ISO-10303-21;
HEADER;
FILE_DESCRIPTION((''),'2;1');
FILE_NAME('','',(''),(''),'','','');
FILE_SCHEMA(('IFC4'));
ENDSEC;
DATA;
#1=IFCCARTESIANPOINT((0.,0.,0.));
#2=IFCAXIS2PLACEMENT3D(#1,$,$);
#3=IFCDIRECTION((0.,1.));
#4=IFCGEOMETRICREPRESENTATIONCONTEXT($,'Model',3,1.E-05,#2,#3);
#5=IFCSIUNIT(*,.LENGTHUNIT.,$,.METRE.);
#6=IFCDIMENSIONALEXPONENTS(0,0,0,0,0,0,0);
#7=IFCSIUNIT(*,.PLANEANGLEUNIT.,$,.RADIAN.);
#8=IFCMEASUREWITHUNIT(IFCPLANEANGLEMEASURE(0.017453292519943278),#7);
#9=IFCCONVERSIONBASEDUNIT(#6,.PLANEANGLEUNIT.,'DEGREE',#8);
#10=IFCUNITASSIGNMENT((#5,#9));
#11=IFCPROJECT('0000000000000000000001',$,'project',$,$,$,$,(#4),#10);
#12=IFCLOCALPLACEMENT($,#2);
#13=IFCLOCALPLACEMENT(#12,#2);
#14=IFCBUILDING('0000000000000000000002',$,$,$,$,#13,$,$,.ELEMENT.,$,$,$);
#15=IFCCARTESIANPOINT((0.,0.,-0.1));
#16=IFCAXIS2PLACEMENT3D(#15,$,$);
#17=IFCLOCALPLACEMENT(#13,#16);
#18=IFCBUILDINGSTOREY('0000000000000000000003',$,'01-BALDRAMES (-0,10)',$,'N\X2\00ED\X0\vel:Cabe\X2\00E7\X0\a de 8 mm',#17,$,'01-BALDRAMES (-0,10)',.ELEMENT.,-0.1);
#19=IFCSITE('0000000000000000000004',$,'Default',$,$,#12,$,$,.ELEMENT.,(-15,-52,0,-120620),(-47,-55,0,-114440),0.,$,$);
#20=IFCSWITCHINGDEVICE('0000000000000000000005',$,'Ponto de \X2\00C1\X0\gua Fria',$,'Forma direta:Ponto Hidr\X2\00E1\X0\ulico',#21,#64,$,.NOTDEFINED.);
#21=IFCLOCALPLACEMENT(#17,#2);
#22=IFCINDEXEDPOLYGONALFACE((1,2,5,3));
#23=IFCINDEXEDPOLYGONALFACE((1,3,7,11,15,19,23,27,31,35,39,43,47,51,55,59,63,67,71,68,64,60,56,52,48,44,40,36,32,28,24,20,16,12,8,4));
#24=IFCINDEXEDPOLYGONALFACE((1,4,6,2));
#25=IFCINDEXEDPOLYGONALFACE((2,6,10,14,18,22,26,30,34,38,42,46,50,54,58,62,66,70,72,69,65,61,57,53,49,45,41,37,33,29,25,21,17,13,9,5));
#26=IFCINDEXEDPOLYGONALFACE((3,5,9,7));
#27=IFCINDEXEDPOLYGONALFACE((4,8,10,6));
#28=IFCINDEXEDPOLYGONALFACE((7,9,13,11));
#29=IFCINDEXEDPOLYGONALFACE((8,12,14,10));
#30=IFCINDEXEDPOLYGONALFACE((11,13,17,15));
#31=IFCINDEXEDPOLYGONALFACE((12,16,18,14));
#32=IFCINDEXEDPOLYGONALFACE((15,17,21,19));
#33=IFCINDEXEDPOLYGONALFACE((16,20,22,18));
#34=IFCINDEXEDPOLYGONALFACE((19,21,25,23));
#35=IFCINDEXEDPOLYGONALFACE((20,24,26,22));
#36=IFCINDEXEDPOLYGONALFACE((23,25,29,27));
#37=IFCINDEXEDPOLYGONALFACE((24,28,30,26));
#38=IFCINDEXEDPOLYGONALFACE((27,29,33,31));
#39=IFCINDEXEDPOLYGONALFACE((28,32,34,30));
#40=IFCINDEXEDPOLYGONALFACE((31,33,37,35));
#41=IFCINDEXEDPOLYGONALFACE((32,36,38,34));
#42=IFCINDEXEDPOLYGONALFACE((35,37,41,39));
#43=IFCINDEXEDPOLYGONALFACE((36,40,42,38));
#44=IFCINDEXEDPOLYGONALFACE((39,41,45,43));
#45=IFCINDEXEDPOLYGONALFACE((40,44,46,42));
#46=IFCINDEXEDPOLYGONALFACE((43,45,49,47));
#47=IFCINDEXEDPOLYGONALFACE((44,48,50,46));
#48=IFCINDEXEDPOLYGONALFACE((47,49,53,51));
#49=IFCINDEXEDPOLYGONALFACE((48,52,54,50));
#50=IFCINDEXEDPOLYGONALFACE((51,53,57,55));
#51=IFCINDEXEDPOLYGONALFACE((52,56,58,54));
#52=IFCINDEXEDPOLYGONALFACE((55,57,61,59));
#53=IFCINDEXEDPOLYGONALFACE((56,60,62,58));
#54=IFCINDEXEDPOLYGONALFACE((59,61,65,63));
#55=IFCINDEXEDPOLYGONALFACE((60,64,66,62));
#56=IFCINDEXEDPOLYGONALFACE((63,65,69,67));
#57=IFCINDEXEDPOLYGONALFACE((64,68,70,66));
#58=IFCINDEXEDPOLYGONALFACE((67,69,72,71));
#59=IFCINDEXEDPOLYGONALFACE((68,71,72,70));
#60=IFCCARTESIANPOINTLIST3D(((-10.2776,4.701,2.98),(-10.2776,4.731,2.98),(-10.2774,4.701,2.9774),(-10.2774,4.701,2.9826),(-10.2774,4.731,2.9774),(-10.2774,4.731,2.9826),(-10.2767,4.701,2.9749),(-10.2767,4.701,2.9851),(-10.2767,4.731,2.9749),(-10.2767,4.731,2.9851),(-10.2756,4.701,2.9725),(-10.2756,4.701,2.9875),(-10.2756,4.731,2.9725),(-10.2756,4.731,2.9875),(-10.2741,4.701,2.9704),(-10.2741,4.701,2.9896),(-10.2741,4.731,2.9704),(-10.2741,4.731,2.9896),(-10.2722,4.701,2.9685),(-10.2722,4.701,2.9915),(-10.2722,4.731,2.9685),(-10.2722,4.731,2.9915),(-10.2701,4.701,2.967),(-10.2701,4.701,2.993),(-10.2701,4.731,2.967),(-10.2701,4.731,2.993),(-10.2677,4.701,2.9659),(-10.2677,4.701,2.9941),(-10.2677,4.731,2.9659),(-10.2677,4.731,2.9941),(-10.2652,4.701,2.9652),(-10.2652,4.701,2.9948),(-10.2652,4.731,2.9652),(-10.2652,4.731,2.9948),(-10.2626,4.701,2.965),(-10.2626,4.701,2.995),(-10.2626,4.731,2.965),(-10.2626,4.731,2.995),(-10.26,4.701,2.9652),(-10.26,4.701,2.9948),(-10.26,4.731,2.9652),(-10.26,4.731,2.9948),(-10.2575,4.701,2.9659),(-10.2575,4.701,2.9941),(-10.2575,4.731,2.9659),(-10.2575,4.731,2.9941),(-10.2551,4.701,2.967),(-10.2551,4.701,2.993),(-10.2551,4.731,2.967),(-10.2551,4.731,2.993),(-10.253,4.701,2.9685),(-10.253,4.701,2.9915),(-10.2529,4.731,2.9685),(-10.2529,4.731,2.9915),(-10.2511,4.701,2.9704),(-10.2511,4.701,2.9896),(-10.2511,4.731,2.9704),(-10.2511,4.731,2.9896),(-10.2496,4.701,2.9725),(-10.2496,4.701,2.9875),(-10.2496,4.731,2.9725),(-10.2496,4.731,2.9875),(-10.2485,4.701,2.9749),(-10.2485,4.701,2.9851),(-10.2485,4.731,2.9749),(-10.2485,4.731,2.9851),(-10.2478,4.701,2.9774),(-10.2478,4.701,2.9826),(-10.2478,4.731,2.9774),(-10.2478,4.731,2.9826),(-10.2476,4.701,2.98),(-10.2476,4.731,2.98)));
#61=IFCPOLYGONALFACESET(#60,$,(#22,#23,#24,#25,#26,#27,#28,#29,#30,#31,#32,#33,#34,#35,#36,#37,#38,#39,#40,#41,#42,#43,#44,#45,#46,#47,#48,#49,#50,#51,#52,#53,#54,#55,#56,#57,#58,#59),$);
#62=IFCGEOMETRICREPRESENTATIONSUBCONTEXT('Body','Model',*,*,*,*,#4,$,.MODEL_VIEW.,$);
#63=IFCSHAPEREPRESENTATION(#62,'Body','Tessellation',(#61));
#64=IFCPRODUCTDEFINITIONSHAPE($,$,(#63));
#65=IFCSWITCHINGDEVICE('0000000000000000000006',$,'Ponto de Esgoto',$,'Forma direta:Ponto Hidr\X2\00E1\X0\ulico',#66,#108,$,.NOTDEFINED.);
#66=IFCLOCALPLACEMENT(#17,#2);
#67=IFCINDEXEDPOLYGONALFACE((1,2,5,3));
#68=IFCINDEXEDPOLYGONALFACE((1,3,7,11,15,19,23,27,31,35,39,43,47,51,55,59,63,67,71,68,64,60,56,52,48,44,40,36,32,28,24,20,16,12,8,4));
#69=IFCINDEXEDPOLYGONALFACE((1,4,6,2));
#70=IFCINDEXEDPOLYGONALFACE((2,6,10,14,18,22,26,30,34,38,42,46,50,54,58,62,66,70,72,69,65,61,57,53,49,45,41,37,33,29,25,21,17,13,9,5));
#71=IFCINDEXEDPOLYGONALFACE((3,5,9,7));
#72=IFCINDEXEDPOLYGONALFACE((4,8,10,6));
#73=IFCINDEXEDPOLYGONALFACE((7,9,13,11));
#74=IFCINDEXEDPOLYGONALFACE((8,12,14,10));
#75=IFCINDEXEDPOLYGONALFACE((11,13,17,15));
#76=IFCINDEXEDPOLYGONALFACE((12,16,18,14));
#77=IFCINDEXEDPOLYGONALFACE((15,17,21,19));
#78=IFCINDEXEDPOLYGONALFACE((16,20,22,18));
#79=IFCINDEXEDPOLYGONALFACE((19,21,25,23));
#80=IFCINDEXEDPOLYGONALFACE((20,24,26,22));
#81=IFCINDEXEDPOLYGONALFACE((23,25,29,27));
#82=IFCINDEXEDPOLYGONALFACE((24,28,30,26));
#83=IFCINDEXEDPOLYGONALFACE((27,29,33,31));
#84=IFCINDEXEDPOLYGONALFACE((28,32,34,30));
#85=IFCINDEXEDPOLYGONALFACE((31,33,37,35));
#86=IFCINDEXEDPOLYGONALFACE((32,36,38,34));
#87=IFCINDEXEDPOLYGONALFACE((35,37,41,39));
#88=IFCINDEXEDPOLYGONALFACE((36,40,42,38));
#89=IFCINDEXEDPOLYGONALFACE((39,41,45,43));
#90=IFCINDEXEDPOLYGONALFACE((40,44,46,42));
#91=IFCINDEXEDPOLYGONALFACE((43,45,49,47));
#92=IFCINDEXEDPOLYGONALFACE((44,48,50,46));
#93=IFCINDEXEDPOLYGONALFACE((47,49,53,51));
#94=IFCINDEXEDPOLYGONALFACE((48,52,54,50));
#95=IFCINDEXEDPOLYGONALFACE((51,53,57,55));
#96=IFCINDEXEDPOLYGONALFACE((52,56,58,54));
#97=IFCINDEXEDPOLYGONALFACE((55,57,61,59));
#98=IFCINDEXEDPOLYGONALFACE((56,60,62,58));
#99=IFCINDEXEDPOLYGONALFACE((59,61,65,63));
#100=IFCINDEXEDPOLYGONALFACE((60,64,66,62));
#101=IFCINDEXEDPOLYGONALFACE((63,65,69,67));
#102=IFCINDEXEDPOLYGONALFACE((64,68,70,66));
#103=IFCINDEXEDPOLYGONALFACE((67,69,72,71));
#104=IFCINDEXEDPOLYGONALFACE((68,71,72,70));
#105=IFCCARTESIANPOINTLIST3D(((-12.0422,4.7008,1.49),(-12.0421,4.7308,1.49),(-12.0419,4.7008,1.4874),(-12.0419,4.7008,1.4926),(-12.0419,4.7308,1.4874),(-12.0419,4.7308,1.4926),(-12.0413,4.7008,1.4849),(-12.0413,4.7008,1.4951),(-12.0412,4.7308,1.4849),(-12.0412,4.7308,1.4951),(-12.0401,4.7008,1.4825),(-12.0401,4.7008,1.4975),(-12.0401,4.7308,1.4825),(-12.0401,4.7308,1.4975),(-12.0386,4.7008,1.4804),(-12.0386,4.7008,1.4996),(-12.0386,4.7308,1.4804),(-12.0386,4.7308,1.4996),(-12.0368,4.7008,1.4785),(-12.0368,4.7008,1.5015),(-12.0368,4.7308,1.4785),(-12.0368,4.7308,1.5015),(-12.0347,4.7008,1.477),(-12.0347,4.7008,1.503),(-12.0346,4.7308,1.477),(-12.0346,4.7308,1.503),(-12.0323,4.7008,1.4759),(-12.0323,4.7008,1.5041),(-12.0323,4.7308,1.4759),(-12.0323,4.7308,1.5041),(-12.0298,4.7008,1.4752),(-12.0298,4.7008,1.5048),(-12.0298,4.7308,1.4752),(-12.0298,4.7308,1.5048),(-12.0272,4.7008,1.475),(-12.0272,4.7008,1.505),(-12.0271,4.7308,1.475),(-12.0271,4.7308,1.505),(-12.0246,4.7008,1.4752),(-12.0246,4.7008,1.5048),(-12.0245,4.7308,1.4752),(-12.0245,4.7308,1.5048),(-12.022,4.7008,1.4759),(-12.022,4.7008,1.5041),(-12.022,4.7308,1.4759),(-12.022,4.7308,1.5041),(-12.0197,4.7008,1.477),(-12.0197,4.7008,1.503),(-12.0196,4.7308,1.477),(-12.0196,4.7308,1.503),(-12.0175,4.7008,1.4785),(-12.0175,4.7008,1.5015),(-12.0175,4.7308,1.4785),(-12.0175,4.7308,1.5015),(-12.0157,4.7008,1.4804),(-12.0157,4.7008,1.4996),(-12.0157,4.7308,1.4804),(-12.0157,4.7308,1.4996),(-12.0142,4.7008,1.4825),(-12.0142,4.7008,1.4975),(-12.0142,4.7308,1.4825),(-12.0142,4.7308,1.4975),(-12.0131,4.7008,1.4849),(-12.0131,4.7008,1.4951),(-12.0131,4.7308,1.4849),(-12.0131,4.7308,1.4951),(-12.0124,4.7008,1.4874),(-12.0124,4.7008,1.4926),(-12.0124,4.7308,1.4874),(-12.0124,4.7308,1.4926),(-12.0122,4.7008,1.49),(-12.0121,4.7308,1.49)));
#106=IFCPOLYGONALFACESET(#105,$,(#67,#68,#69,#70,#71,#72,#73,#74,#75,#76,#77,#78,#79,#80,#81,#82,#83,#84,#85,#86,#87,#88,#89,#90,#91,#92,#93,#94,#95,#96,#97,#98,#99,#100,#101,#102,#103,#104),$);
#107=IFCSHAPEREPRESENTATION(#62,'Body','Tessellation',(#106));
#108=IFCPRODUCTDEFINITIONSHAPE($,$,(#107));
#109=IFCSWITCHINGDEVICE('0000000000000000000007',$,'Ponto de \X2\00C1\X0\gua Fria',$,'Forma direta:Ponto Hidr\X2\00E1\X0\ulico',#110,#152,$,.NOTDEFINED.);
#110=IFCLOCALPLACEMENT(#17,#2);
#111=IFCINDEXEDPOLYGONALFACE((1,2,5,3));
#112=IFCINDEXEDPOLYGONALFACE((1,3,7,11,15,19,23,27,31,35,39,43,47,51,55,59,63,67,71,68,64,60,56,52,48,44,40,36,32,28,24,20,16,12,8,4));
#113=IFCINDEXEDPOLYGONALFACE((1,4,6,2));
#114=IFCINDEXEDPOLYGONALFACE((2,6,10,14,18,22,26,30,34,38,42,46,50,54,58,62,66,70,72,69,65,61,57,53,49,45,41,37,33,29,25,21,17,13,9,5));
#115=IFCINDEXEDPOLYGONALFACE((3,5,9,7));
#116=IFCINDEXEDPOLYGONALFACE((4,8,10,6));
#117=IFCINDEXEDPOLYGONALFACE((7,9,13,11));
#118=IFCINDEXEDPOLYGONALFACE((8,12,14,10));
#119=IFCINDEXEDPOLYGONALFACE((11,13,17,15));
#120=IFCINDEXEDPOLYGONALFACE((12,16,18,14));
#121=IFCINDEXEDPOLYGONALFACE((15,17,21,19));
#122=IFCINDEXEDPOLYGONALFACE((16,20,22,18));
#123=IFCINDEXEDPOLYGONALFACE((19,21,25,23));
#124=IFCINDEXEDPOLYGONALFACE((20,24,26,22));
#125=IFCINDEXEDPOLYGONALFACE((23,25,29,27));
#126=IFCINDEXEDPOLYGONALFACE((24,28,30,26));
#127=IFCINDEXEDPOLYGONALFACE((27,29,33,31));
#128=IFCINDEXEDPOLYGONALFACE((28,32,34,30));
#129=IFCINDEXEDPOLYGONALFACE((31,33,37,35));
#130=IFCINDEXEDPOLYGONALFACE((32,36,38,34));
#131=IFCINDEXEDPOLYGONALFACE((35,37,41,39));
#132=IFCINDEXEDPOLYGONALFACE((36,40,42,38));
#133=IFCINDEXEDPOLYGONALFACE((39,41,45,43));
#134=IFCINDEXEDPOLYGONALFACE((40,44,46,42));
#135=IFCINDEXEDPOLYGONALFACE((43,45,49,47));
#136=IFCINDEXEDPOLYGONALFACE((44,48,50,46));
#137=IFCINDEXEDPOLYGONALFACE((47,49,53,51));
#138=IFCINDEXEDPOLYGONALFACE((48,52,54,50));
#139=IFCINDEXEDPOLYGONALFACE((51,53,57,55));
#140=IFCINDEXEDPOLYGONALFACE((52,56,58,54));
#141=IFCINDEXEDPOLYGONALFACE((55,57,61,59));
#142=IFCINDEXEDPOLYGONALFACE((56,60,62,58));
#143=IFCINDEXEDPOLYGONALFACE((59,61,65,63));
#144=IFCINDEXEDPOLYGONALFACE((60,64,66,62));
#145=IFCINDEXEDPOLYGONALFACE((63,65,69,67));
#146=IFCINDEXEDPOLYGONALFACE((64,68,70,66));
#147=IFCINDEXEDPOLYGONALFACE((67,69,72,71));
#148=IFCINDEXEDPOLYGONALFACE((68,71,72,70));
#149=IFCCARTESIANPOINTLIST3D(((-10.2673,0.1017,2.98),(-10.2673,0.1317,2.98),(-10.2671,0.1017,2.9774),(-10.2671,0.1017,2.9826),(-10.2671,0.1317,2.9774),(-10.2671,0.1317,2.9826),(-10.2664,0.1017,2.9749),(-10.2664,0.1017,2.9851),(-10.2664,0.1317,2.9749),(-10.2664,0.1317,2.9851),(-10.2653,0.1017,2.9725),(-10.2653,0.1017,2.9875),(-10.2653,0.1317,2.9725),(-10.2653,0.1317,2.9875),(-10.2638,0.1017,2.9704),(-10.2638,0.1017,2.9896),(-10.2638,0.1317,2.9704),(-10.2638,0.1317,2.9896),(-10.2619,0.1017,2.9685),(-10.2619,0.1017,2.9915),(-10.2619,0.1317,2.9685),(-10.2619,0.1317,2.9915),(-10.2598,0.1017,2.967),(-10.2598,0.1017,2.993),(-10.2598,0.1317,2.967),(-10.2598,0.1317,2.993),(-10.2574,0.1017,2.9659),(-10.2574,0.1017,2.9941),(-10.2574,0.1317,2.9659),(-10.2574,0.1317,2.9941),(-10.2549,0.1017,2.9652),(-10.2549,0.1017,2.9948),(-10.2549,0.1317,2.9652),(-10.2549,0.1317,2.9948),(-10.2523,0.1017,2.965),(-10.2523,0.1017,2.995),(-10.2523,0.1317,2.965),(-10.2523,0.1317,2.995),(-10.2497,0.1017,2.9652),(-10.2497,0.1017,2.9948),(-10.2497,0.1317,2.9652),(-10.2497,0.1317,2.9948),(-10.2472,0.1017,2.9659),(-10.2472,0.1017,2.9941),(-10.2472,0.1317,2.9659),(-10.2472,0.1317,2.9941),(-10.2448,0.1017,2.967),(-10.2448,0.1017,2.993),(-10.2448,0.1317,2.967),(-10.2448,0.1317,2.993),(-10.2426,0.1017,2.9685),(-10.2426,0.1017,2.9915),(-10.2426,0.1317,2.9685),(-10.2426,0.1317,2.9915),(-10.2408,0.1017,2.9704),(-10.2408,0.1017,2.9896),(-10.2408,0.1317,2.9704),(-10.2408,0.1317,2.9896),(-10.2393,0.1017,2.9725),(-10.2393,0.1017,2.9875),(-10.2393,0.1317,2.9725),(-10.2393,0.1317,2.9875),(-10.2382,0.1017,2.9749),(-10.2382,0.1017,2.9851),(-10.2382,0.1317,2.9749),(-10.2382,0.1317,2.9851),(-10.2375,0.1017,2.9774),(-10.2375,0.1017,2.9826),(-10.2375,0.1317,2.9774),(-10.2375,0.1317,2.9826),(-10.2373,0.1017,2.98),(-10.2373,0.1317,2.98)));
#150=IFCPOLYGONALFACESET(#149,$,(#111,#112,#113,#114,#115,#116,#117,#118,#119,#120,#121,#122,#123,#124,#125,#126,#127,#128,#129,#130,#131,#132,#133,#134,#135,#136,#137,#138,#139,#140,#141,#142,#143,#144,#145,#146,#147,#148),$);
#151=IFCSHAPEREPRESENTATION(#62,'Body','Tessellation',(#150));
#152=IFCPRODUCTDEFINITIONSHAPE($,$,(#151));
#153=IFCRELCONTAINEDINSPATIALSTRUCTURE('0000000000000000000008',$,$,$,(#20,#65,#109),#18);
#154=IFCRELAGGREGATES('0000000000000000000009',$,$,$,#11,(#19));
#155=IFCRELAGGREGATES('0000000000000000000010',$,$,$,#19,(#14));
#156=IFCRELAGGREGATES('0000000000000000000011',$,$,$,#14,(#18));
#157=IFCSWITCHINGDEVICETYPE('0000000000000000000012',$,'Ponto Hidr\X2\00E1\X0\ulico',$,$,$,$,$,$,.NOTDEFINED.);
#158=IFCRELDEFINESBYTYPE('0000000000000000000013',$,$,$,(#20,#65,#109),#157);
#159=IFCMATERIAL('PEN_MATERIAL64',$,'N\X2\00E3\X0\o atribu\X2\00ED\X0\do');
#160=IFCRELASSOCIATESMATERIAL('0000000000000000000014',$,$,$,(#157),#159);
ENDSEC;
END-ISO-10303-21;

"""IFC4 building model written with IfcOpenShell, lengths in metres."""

from ifc_helpers import new_model, entity, si_unit, converted_unit, direction, frame, origin, place, context, subcontext, project, spatial, indexed_curve, outline, extrude, material, type_object, element, save


model = new_model("IFC4")

# Units and contexts
model_context = context("Model", 3, precision=1e-05, world=origin(), true_north=direction((0.0, 1.0)))
body_context = subcontext(model_context, "Body", "Model", "MODEL_VIEW")
ifc_project = project(units=[si_unit("LENGTHUNIT", "METRE"), converted_unit("PLANEANGLEUNIT", "DEGREE", entity("IfcPlaneAngleMeasure", 0.017453292519943278), si_unit("PLANEANGLEUNIT", "RADIAN"), dimensions=[0, 0, 0, 0, 0, 0, 0])], contexts=[model_context])

# Site, building, storey
site_placement = place(None, origin())
site = spatial("IfcSite", under=ifc_project, at=site_placement, Name="Default", CompositionType="ELEMENT", RefLatitude=(-15, -52, 0, -120620), RefLongitude=(-47, -55, 0, -114440), RefElevation=0.0)
building_placement = place(site_placement, origin())
building = spatial("IfcBuilding", under=site, at=building_placement, CompositionType="ELEMENT")
storey_placement = place(building_placement, frame((0.0, 0.0, -0.1)))
storey = spatial("IfcBuildingStorey", under=building, at=storey_placement, Name="01-BALDRAMES (-0,10)", ObjectType="Nível:Cabeça de 8 mm", LongName="01-BALDRAMES (-0,10)", CompositionType="ELEMENT", Elevation=-0.1)

# Switching devices
ifc_material_1 = material(Name="PEN_MATERIAL64", Category="Não atribuído")
switching_device_type = type_object("IfcSwitchingDeviceType", Name="Ponto Hidráulico", PredefinedType="NOTDEFINED", material=ifc_material_1)
switching_device_1_placement = place(storey_placement, origin())
element("IfcSwitchingDevice", 1, at=switching_device_1_placement, inside=storey, type_object=switching_device_type, Name="Ponto de Água Fria", ObjectType="Forma direta:Ponto Hidráulico", PredefinedType="NOTDEFINED", context=body_context, shape_type="SweptSolid", body=[
    extrude(outline(indexed_curve([(-0.0013, -0.0149), (0.0013, -0.0149), (0.0039, -0.0145), (0.0063, -0.0136), (0.0086, -0.0123), (0.0106, -0.0106), (0.0123, -0.0086), (0.0136, -0.0063), (0.0145, -0.0039), (0.0149, -0.0013), (0.0149, 0.0013), (0.0145, 0.0039), (0.0136, 0.0063), (0.0123, 0.0086), (0.0106, 0.0106), (0.0086, 0.0123), (0.0063, 0.0136), (0.0039, 0.0145), (0.0013, 0.0149), (-0.0013, 0.0149), (-0.0039, 0.0145), (-0.0063, 0.0136), (-0.0086, 0.0123), (-0.0106, 0.0106), (-0.0123, 0.0086), (-0.0136, 0.0063), (-0.0145, 0.0039), (-0.0149, 0.0013), (-0.0149, -0.0013), (-0.0145, -0.0039), (-0.0136, -0.0063), (-0.0123, -0.0086), (-0.0106, -0.0106), (-0.0086, -0.0123), (-0.0063, -0.0136), (-0.0039, -0.0145), (-0.0013, -0.0149)], self_intersect=False)), frame((-10.2626, 4.701, 2.98), z_axis=(0.000299, 1.0, 0.0), x_axis=(-0.996195, 0.000298, -0.087156)), (0.0, 0.0, 1.0), 0.03),
])
switching_device_2_placement = place(storey_placement, origin())
element("IfcSwitchingDevice", 2, at=switching_device_2_placement, inside=storey, type_object=switching_device_type, Name="Ponto de Esgoto", ObjectType="Forma direta:Ponto Hidráulico", PredefinedType="NOTDEFINED", context=body_context, shape_type="SweptSolid", body=[
    extrude(outline(indexed_curve([(-0.0013, -0.0149), (0.0013, -0.0149), (0.0039, -0.0145), (0.0063, -0.0136), (0.0086, -0.0123), (0.0106, -0.0106), (0.0123, -0.0086), (0.0136, -0.0063), (0.0145, -0.0039), (0.0149, -0.0013), (0.0149, 0.0013), (0.0145, 0.0039), (0.0136, 0.0063), (0.0123, 0.0086), (0.0106, 0.0106), (0.0086, 0.0123), (0.0063, 0.0136), (0.0039, 0.0145), (0.0013, 0.0149), (-0.0013, 0.0149), (-0.0039, 0.0145), (-0.0063, 0.0136), (-0.0086, 0.0123), (-0.0106, 0.0106), (-0.0123, 0.0086), (-0.0136, 0.0063), (-0.0145, 0.0039), (-0.0149, 0.0013), (-0.0149, -0.0013), (-0.0145, -0.0039), (-0.0136, -0.0063), (-0.0123, -0.0086), (-0.0106, -0.0106), (-0.0086, -0.0123), (-0.0063, -0.0136), (-0.0039, -0.0145), (-0.0013, -0.0149)], self_intersect=False)), frame((-12.0272, 4.7008, 1.49), z_axis=(0.000299, 1.0, 0.0), x_axis=(-0.996195, 0.000298, -0.087156)), (0.0, 0.0, 1.0), 0.03),
])
switching_device_3_placement = place(storey_placement, origin())
element("IfcSwitchingDevice", 3, at=switching_device_3_placement, inside=storey, type_object=switching_device_type, Name="Ponto de Água Fria", ObjectType="Forma direta:Ponto Hidráulico", PredefinedType="NOTDEFINED", context=body_context, shape_type="SweptSolid", body=[
    extrude(outline(indexed_curve([(-0.0013, -0.0149), (0.0013, -0.0149), (0.0039, -0.0145), (0.0063, -0.0136), (0.0086, -0.0123), (0.0106, -0.0106), (0.0123, -0.0086), (0.0136, -0.0063), (0.0145, -0.0039), (0.0149, -0.0013), (0.0149, 0.0013), (0.0145, 0.0039), (0.0136, 0.0063), (0.0123, 0.0086), (0.0106, 0.0106), (0.0086, 0.0123), (0.0063, 0.0136), (0.0039, 0.0145), (0.0013, 0.0149), (-0.0013, 0.0149), (-0.0039, 0.0145), (-0.0063, 0.0136), (-0.0086, 0.0123), (-0.0106, 0.0106), (-0.0123, 0.0086), (-0.0136, 0.0063), (-0.0145, 0.0039), (-0.0149, 0.0013), (-0.0149, -0.0013), (-0.0145, -0.0039), (-0.0136, -0.0063), (-0.0123, -0.0086), (-0.0106, -0.0106), (-0.0086, -0.0123), (-0.0063, -0.0136), (-0.0039, -0.0145), (-0.0013, -0.0149)], self_intersect=False)), frame((-10.2523, 0.1017, 2.98), z_axis=(0.000299, 1.0, 0.0), x_axis=(-0.996195, 0.000298, -0.087156)), (0.0, 0.0, 1.0), 0.03),
])

save(model, "model.ifc")
